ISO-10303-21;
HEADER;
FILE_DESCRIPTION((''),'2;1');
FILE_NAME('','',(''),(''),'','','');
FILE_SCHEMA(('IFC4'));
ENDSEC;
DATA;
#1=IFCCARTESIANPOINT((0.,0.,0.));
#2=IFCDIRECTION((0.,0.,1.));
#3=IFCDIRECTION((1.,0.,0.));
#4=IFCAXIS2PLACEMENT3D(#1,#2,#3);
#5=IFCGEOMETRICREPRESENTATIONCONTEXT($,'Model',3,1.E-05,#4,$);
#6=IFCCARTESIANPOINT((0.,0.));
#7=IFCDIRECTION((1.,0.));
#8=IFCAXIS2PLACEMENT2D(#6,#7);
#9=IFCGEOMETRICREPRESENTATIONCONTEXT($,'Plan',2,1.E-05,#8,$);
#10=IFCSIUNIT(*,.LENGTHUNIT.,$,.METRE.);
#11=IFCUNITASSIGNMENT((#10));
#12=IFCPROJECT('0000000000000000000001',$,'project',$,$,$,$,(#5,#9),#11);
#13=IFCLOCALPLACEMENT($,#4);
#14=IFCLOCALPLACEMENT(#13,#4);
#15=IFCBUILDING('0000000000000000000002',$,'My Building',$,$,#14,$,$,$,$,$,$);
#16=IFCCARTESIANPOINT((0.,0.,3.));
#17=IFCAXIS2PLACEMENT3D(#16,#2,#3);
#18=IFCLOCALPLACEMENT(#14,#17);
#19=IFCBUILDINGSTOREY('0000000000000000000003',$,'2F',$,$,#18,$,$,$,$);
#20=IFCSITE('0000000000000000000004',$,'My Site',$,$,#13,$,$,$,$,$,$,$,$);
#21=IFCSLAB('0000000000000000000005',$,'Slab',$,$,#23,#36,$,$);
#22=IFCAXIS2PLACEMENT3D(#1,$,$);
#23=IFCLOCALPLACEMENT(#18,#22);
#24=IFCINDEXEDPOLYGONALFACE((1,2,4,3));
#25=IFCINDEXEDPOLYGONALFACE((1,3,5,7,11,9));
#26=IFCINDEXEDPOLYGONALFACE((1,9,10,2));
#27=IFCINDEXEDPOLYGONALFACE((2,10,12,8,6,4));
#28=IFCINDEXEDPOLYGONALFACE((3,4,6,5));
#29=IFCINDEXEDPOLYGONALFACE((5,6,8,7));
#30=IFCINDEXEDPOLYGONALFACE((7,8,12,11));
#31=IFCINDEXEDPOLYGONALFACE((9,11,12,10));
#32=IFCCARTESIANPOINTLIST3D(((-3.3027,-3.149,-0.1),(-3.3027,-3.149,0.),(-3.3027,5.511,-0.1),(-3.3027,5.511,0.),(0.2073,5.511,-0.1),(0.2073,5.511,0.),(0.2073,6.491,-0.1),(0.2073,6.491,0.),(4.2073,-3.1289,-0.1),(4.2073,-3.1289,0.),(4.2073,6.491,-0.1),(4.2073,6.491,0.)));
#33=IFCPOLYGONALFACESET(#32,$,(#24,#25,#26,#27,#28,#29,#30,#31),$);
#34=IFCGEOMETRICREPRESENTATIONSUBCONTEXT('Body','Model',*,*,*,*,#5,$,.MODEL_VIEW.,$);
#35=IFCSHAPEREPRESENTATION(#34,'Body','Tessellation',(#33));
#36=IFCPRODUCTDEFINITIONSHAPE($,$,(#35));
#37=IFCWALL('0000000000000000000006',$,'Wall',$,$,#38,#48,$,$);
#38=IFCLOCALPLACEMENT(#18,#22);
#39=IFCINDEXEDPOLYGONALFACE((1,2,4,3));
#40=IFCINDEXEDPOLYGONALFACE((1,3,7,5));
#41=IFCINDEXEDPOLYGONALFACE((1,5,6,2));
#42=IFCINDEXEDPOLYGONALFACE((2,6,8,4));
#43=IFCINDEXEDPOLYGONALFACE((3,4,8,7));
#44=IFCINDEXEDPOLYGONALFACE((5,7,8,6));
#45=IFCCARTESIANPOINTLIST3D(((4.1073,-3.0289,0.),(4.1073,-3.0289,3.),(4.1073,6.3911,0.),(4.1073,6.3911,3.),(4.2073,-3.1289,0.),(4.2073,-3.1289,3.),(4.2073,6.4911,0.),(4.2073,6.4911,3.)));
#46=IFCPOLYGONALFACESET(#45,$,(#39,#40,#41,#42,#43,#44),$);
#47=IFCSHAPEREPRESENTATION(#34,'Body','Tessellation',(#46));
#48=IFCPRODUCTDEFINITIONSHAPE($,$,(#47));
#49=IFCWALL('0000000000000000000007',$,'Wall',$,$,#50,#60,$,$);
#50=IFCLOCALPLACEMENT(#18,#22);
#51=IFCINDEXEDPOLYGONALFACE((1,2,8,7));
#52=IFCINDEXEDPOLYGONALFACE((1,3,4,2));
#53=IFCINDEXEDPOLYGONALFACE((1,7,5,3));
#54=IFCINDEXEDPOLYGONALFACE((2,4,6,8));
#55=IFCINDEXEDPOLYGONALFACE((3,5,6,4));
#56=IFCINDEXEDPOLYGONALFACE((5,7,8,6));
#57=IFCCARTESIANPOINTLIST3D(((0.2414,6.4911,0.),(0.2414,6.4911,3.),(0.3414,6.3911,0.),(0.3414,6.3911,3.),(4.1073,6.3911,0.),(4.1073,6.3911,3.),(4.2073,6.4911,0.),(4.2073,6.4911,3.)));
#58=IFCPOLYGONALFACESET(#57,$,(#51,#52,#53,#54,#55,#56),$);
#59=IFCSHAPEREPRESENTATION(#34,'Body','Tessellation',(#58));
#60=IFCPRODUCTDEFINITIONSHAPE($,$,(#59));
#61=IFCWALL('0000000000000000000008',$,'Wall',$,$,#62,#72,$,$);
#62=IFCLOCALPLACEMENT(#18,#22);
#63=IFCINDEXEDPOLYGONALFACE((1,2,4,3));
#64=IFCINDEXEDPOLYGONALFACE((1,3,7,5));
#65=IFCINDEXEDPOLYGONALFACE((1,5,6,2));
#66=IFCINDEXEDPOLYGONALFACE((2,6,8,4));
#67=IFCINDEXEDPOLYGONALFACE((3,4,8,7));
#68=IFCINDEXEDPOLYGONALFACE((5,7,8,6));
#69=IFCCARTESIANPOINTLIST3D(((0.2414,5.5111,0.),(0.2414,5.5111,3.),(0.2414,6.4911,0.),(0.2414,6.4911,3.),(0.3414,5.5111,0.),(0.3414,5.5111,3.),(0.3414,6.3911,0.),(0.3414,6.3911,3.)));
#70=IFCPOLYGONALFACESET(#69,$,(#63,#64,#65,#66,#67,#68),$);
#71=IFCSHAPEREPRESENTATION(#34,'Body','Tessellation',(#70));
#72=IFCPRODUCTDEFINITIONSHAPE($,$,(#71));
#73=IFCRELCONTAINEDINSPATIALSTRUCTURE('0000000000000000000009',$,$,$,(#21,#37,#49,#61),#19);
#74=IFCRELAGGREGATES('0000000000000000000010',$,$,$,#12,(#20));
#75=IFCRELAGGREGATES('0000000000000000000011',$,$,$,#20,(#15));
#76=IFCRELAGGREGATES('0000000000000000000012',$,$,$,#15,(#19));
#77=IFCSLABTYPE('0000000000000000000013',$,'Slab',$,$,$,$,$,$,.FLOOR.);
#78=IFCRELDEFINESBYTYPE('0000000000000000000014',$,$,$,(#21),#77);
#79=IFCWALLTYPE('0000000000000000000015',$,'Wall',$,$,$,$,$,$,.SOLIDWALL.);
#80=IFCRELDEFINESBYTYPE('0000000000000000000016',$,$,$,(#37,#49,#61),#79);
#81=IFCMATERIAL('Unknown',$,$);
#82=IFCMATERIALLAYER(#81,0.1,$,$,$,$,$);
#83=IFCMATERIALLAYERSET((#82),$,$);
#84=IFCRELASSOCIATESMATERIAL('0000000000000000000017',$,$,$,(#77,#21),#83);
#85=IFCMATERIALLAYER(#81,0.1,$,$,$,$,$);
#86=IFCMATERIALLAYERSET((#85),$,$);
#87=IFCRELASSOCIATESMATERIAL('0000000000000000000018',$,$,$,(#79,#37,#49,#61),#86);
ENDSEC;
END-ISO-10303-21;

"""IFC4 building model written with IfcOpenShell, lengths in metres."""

from ifc_helpers import new_model, si_unit, frame, origin_with_axes, origin_2d_with_axis, place, context, subcontext, project, spatial, line, indexed_curve, outline, extrude, material, layer, layer_set, layer_usage, type_object, element, save


model = new_model("IFC4")

# Units and contexts
model_context = context("Model", 3, precision=1e-05, world=origin_with_axes())
plan_context = context("Plan", 2, precision=1e-05, world=origin_2d_with_axis())
body_context_1 = subcontext(model_context, "Body", "Model", "MODEL_VIEW")
ifc_project = project(units=[si_unit("LENGTHUNIT", "METRE")], contexts=[model_context, plan_context])

# Site, building, storey
site_placement = place(None, origin_with_axes())
site = spatial("IfcSite", under=ifc_project, at=site_placement, Name="My Site")
building_placement = place(site_placement, origin_with_axes())
building = spatial("IfcBuilding", under=site, at=building_placement, Name="My Building")
storey_placement = place(building_placement, frame((0.0, 0.0, 3.0), z_axis=(0.0, 0.0, 1.0), x_axis=(1.0, 0.0, 0.0)))
storey = spatial("IfcBuildingStorey", under=building, at=storey_placement, Name="2F")

# Slab
ifc_material = material(Name="Unknown")
ifc_layer_1 = layer(ifc_material, 0.1)
ifc_layer_set_1 = layer_set([ifc_layer_1])
ifc_layer_usage_1 = layer_usage(ifc_layer_set_1, "AXIS3", "POSITIVE", -0.1)
slab_type = type_object("IfcSlabType", Name="Slab", PredefinedType="FLOOR", material=ifc_layer_set_1)
slab_placement = place(storey_placement, frame((4.2073, -3.1289, 0.0), z_axis=(0.0, 0.0, 1.0), x_axis=(1.0, 0.0, 0.0)))
element("IfcSlab", 1, at=slab_placement, inside=storey, type_object=slab_type, material=ifc_layer_usage_1, Name="Slab", context=body_context_1, shape_type="SweptSolid", body=[
    extrude(outline(indexed_curve([(0.0, 0.0), (0.0, 9.62), (-4.0, 9.62), (-4.0, 8.6399), (-7.51, 8.6399), (-7.51, -0.0201), (0.0, 0.0)])), frame((0.0, 0.0, -0.1), z_axis=(0.0, 0.0, 1.0), x_axis=(1.0, 0.0, 0.0)), (0.0, 0.0, 1.0), 0.1),
])

# Walls
ifc_layer_2 = layer(ifc_material, 0.1)
ifc_layer_set_2 = layer_set([ifc_layer_2])
ifc_layer_usage_2 = layer_usage(ifc_layer_set_2, "AXIS2", "POSITIVE", 0.0)
wall_type = type_object("IfcWallType", Name="Wall", PredefinedType="SOLIDWALL", material=ifc_layer_set_2)
wall_1_placement = place(storey_placement, frame((4.2073, -3.1289, 0.0), z_axis=(0.0, 0.0, 1.0), x_axis=(0.0, 1.0, 0.0)))
element("IfcWall", 2, at=wall_1_placement, inside=storey, type_object=wall_type, material=ifc_layer_usage_2, Name="Wall", context=body_context_1, shape_type="SweptSolid", body=[
    extrude(outline(indexed_curve([(0.0, 0.0), (0.1, 0.1), (9.52, 0.1), (9.62, 0.0)], segments=[line(1, 2, 3, 4, 1)])), origin_with_axes(), (0.0, 0.0, 1.0), 3.0),
])
ifc_layer_usage_3 = layer_usage(ifc_layer_set_2, "AXIS2", "POSITIVE", 0.0)
wall_2_placement = place(storey_placement, frame((4.2073, 6.4911, 0.0), z_axis=(0.0, 0.0, 1.0), x_axis=(-1.0, 0.0, 0.0)))
element("IfcWall", 3, at=wall_2_placement, inside=storey, type_object=wall_type, material=ifc_layer_usage_3, Name="Wall", context=body_context_1, shape_type="SweptSolid", body=[
    extrude(outline(indexed_curve([(0.0, 0.0), (0.1, 0.1), (3.8658, 0.1), (3.9658, 0.0)], segments=[line(1, 2, 3, 4, 1)])), origin_with_axes(), (0.0, 0.0, 1.0), 3.0),
])
ifc_layer_usage_4 = layer_usage(ifc_layer_set_2, "AXIS2", "POSITIVE", 0.0)
wall_3_placement = place(storey_placement, frame((0.2414, 6.4911, 0.0), z_axis=(0.0, 0.0, 1.0), x_axis=(0.0, -1.0, 0.0)))
element("IfcWall", 4, at=wall_3_placement, inside=storey, type_object=wall_type, material=ifc_layer_usage_4, Name="Wall", context=body_context_1, shape_type="SweptSolid", body=[
    extrude(outline(indexed_curve([(0.0, 0.0), (0.1, 0.1), (0.98, 0.1), (0.98, 0.0)], segments=[line(1, 2, 3, 4, 1)])), origin_with_axes(), (0.0, 0.0, 1.0), 3.0),
])

save(model, "model.ifc")
